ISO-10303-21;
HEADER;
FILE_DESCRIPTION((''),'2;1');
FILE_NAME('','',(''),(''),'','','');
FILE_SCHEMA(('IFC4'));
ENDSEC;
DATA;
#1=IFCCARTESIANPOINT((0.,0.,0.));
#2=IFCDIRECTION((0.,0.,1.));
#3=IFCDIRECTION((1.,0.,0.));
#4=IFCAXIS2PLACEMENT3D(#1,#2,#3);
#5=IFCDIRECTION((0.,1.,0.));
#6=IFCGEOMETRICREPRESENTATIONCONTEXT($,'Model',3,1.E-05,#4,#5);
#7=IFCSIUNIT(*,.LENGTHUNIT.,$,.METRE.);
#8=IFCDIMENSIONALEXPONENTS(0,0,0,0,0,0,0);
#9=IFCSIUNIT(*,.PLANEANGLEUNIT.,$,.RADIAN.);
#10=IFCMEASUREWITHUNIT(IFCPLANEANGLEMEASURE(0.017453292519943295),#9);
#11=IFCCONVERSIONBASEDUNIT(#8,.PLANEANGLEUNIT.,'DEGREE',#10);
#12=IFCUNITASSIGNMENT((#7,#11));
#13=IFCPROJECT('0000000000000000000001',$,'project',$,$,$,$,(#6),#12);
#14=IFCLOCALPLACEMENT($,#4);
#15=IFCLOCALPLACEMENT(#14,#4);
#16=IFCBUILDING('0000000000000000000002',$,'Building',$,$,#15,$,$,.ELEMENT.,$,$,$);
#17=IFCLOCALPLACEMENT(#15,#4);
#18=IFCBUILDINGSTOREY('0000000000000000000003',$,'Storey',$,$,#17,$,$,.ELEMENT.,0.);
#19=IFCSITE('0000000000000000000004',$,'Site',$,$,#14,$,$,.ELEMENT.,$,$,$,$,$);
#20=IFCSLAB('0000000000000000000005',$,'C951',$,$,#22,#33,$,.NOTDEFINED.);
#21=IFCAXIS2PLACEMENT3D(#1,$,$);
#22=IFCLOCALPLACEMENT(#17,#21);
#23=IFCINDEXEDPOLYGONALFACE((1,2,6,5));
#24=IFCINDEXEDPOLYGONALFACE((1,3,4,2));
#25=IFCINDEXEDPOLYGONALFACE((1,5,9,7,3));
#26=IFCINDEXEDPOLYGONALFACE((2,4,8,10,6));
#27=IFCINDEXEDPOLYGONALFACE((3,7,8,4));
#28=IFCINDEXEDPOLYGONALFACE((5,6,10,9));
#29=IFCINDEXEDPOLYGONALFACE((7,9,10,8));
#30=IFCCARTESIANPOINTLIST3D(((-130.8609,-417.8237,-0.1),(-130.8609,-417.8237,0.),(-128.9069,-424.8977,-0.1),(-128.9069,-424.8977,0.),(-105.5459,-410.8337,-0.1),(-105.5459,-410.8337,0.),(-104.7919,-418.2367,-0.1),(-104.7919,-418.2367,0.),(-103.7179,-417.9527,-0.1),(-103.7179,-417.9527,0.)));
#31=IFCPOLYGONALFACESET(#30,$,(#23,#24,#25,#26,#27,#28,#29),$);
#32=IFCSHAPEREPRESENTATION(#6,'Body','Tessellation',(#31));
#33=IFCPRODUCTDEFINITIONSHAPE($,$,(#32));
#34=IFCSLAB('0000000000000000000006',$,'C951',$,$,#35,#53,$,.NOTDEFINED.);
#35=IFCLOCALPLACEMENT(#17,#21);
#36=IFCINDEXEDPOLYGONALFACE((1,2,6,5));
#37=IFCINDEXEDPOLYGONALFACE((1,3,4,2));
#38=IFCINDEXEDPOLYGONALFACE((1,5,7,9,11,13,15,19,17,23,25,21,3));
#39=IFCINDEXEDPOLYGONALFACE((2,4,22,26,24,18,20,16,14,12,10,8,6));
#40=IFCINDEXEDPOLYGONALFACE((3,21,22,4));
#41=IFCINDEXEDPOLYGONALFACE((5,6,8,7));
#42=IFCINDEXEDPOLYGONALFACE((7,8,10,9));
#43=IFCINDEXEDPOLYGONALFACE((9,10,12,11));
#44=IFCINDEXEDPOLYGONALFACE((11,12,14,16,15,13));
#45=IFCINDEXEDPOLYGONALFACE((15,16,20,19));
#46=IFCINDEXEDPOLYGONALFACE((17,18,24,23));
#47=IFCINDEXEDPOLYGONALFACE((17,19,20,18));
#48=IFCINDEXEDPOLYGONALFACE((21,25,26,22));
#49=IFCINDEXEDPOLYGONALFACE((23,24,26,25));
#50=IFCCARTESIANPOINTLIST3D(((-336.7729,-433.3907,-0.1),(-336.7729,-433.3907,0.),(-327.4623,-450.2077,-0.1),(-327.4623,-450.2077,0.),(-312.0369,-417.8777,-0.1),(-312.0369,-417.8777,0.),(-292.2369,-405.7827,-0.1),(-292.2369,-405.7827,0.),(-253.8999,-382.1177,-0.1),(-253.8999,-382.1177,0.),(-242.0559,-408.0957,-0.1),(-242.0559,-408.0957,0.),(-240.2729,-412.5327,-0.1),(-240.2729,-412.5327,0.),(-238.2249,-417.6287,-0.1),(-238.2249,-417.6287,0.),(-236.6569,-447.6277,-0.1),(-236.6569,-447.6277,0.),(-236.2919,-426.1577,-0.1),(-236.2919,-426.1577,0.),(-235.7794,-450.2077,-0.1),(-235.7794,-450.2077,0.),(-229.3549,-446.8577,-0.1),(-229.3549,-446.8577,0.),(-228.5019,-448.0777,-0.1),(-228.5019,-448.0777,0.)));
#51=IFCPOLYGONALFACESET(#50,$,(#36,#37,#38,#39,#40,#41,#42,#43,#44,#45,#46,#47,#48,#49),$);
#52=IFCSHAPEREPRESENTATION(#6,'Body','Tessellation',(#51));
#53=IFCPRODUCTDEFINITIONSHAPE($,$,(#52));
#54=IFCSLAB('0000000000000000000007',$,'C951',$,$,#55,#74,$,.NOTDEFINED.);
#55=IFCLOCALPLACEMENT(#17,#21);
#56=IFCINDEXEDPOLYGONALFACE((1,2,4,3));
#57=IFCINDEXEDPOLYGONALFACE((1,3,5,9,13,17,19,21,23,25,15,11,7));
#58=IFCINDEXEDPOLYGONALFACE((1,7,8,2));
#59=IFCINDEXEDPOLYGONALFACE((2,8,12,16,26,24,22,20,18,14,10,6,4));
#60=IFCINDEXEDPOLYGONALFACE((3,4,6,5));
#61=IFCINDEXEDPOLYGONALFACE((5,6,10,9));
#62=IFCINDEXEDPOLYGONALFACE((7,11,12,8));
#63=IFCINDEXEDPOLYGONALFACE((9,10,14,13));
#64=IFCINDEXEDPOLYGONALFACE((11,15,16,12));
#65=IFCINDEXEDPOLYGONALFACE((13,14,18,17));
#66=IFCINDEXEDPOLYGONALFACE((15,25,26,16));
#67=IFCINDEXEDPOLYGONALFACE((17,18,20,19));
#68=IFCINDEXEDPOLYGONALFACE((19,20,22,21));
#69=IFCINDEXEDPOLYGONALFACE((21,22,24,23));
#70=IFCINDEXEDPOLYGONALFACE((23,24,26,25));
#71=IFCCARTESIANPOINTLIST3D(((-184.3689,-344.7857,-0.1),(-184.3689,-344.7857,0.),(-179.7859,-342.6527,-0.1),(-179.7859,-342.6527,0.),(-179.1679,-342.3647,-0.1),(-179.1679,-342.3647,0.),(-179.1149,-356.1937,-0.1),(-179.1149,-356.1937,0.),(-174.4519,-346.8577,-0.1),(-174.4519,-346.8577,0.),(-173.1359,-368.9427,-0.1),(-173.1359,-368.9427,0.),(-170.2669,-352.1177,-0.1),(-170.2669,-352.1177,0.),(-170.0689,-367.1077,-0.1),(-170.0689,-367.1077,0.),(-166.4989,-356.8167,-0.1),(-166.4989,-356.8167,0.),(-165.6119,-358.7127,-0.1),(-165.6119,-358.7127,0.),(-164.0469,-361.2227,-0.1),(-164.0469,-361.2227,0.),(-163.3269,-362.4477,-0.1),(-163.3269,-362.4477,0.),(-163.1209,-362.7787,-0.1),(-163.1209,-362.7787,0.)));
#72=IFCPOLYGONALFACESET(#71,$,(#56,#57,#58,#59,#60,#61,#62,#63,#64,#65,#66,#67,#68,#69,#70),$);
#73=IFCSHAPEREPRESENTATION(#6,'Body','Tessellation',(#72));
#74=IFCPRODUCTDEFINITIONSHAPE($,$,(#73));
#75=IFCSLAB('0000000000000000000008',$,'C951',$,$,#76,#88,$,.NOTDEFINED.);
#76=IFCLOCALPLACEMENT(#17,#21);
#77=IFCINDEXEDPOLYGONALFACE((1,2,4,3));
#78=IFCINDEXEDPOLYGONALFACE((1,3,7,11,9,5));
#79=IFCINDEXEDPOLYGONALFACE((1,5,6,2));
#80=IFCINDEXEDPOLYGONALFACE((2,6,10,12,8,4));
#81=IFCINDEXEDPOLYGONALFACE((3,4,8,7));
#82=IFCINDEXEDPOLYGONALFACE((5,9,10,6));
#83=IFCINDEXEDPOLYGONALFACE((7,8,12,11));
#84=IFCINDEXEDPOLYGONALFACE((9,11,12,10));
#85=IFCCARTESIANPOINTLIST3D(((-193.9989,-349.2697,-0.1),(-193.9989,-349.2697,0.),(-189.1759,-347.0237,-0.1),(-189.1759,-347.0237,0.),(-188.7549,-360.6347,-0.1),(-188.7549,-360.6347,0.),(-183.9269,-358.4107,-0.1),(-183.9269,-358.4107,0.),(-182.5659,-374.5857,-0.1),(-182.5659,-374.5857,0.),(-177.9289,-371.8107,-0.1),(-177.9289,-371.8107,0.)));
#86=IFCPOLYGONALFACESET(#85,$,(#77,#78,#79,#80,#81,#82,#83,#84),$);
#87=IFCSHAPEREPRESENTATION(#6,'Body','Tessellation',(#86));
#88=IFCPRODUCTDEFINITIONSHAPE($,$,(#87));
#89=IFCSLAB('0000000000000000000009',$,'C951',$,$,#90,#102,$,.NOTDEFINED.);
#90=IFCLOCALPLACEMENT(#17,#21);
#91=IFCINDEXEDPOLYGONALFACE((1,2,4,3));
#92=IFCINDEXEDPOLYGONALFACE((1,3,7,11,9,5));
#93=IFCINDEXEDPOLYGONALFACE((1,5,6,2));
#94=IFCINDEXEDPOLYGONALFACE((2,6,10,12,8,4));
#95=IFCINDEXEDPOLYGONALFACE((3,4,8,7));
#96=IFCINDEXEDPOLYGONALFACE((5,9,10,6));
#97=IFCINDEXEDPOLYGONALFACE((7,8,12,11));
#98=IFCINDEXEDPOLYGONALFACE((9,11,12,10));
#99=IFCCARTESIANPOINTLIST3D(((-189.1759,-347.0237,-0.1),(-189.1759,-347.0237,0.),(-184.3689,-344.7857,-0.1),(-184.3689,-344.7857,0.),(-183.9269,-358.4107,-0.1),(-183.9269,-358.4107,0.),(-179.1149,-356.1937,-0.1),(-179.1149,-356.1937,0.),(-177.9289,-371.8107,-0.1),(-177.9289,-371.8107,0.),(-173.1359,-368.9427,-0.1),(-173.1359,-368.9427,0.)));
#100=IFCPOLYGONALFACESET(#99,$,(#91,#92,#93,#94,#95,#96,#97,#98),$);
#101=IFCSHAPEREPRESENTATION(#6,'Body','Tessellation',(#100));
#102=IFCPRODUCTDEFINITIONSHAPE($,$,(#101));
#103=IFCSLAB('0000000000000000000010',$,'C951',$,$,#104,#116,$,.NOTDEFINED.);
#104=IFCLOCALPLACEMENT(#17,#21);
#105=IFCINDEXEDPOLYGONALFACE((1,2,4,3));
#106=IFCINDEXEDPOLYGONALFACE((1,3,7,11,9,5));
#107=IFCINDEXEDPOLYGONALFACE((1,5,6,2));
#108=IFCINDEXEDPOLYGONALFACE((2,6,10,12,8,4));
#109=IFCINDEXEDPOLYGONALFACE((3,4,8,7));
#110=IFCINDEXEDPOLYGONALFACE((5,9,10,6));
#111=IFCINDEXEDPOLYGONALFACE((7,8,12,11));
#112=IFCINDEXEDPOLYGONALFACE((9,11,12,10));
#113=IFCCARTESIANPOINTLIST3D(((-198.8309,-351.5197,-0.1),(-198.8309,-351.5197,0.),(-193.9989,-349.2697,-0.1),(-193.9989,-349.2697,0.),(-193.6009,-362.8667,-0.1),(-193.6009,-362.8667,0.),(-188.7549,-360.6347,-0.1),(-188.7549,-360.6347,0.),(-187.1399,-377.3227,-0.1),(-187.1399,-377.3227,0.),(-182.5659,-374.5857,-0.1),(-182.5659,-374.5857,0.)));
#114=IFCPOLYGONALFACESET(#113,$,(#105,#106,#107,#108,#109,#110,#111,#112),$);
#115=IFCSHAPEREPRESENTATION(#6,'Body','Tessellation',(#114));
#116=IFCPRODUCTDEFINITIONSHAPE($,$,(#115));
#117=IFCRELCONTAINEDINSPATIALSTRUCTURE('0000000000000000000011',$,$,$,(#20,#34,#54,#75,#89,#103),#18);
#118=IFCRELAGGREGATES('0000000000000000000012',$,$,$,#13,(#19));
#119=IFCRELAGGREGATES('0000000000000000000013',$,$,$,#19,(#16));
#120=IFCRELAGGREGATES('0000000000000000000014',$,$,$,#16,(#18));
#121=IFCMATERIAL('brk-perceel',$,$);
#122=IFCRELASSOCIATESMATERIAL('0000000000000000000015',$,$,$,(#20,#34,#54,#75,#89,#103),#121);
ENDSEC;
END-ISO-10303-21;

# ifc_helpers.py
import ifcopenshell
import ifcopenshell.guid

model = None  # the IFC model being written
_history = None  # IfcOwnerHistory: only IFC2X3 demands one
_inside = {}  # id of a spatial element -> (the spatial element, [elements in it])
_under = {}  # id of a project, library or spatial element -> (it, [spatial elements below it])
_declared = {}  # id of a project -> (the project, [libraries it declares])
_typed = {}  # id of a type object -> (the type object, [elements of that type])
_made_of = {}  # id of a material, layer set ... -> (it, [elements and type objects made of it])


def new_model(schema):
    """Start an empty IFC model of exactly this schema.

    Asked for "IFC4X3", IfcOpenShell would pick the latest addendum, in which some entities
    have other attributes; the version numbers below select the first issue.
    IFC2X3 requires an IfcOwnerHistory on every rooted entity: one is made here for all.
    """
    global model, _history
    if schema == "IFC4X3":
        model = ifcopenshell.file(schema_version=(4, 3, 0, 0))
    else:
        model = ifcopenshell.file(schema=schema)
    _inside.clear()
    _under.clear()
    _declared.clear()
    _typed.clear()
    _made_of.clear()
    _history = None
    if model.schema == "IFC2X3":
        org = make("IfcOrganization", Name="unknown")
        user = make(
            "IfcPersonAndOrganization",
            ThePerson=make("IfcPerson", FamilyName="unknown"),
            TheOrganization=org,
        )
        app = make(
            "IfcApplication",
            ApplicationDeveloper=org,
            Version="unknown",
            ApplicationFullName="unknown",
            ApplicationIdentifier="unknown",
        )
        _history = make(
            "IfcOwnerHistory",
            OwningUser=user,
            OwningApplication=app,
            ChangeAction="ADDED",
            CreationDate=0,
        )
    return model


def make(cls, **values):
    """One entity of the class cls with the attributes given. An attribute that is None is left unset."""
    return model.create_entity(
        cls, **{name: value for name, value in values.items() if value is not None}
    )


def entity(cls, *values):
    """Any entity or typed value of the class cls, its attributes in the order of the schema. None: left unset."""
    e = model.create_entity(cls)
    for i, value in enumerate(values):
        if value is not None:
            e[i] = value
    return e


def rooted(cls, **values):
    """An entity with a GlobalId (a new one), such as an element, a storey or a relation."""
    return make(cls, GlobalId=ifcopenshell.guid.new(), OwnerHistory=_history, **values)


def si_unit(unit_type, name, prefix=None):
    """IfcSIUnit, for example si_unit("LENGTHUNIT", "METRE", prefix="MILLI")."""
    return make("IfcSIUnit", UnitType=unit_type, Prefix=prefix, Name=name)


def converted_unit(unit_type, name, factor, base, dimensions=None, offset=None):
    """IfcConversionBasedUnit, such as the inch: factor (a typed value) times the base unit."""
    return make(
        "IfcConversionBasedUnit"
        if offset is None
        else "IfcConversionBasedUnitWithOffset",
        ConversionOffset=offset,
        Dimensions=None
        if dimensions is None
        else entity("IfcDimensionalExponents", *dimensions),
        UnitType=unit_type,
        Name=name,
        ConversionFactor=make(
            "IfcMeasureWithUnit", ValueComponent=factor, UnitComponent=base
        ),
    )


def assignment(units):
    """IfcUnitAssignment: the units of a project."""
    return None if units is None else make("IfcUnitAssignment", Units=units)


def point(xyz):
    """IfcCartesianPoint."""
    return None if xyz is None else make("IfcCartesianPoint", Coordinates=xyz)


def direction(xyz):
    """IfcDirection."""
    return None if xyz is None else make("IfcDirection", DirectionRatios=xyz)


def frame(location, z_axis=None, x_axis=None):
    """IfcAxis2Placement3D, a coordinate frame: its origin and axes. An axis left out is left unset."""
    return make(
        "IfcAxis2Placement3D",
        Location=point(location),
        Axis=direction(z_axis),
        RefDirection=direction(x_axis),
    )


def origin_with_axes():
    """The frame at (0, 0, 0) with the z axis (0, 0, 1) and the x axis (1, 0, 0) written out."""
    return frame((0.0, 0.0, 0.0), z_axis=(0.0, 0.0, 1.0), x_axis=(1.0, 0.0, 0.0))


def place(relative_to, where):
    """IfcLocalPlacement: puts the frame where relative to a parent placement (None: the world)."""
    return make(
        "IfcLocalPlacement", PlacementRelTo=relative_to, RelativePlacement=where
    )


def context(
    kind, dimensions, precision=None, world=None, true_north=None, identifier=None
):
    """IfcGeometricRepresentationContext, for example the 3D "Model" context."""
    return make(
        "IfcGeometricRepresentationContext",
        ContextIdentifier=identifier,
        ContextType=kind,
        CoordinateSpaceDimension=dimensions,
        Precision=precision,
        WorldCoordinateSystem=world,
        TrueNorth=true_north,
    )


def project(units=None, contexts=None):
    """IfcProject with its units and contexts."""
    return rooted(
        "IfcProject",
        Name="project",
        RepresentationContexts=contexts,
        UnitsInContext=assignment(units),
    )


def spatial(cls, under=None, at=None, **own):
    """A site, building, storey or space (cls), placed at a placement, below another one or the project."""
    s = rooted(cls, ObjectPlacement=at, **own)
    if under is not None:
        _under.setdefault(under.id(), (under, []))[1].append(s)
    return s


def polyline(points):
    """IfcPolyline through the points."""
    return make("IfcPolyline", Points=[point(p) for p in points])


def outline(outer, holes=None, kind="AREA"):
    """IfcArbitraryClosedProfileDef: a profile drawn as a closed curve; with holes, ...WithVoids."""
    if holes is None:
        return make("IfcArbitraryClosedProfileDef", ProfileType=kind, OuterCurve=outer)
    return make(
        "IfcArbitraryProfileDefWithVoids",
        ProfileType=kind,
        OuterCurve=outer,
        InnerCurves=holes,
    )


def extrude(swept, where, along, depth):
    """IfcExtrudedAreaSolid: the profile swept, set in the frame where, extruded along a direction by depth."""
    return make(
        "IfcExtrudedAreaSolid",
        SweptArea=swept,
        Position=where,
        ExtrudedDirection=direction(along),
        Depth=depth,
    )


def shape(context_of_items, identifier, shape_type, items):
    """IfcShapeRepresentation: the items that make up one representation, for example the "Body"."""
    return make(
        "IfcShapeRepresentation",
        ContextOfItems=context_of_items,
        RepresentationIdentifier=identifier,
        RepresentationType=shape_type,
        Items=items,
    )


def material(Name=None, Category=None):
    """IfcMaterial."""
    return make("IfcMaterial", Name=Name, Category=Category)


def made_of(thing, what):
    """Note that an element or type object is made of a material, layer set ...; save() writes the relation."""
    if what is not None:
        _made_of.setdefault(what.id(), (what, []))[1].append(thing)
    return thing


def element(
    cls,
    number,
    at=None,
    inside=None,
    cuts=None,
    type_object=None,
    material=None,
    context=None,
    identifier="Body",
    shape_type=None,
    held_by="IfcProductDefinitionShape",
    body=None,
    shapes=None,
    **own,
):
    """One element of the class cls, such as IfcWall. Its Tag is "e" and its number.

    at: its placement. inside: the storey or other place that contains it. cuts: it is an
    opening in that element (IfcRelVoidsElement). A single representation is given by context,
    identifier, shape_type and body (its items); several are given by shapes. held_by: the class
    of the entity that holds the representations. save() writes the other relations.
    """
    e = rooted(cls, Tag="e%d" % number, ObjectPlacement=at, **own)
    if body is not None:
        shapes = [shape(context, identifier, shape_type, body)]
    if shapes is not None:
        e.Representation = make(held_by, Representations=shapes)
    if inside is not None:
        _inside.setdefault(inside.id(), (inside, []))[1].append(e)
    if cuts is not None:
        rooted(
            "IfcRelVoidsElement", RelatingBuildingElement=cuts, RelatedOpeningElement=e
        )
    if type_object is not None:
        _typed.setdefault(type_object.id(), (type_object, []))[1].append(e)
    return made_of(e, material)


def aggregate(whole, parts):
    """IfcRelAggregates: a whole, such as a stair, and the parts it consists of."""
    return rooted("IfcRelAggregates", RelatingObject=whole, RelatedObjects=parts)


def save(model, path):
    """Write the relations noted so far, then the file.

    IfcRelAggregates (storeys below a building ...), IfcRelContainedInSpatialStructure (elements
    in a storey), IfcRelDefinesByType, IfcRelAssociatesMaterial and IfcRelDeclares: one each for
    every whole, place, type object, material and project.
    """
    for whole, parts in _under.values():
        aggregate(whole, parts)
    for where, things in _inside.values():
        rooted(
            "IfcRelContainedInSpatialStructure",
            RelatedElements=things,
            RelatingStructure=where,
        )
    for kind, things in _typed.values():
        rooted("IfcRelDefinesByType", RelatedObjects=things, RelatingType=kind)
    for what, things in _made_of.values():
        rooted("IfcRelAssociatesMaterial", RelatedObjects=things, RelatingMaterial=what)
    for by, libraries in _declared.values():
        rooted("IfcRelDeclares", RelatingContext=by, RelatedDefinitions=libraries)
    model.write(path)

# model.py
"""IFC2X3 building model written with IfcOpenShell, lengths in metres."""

from ifc_helpers import new_model, entity, si_unit, converted_unit, direction, frame, origin_with_axes, place, context, project, spatial, polyline, outline, extrude, material, element, save


model = new_model("IFC2X3")

# Units and contexts
model_context = context("Model", 3, precision=1e-05, world=origin_with_axes(), true_north=direction((0.0, 1.0, 0.0)))
ifc_project = project(units=[si_unit("LENGTHUNIT", "METRE"), converted_unit("PLANEANGLEUNIT", "DEGREE", entity("IfcPlaneAngleMeasure", 0.017453292519943295), si_unit("PLANEANGLEUNIT", "RADIAN"), dimensions=[0, 0, 0, 0, 0, 0, 0])], contexts=[model_context])

# Site, building, storey
site_placement = place(None, origin_with_axes())
site = spatial("IfcSite", under=ifc_project, at=site_placement, Name="Site", CompositionType="ELEMENT")
building_placement = place(site_placement, origin_with_axes())
building = spatial("IfcBuilding", under=site, at=building_placement, Name="Building", CompositionType="ELEMENT")
storey_placement = place(building_placement, origin_with_axes())
storey = spatial("IfcBuildingStorey", under=building, at=storey_placement, Name="Storey", CompositionType="ELEMENT", Elevation=0.0)

# Slabs
ifc_material = material(Name="brk-perceel")
slab_1_placement = place(storey_placement, frame((0.0, 0.0, -0.1), z_axis=(0.0, 0.0, 1.0), x_axis=(1.0, 0.0, 0.0)))
element("IfcSlab", 1, at=slab_1_placement, inside=storey, material=ifc_material, Name="C951", PredefinedType="NOTDEFINED", context=model_context, shape_type="SweptSolid", body=[
    extrude(outline(polyline([(-104.7919, -418.2367), (-128.9069, -424.8977), (-130.8609, -417.8237), (-105.5459, -410.8337), (-103.7179, -417.9527), (-104.7919, -418.2367)])), origin_with_axes(), (0.0, 0.0, 1.0), 0.1),
])
slab_2_placement = place(storey_placement, frame((0.0, 0.0, -0.1), z_axis=(0.0, 0.0, 1.0), x_axis=(1.0, 0.0, 0.0)))
element("IfcSlab", 2, at=slab_2_placement, inside=storey, material=ifc_material, Name="C951", PredefinedType="NOTDEFINED", context=model_context, shape_type="SweptSolid", body=[
    extrude(outline(polyline([(-336.7729, -433.3907), (-312.0369, -417.8777), (-292.2369, -405.7827), (-253.8999, -382.1177), (-242.0559, -408.0957), (-240.2729, -412.5327), (-238.2249, -417.6287), (-236.2919, -426.1577), (-236.6569, -447.6277), (-229.3549, -446.8577), (-228.5019, -448.0777), (-235.7794, -450.2077), (-327.4623, -450.2077), (-336.7729, -433.3907)])), origin_with_axes(), (0.0, 0.0, 1.0), 0.1),
])
slab_3_placement = place(storey_placement, frame((0.0, 0.0, -0.1), z_axis=(0.0, 0.0, 1.0), x_axis=(1.0, 0.0, 0.0)))
element("IfcSlab", 3, at=slab_3_placement, inside=storey, material=ifc_material, Name="C951", PredefinedType="NOTDEFINED", context=model_context, shape_type="SweptSolid", body=[
    extrude(outline(polyline([(-170.0689, -367.1077), (-173.1359, -368.9427), (-179.1149, -356.1937), (-184.3689, -344.7857), (-179.7859, -342.6527), (-179.1679, -342.3647), (-174.4519, -346.8577), (-170.2669, -352.1177), (-166.4989, -356.8167), (-165.6119, -358.7127), (-164.0469, -361.2227), (-163.3269, -362.4477), (-163.1209, -362.7787), (-170.0689, -367.1077)])), origin_with_axes(), (0.0, 0.0, 1.0), 0.1),
])
slab_4_placement = place(storey_placement, frame((0.0, 0.0, -0.1), z_axis=(0.0, 0.0, 1.0), x_axis=(1.0, 0.0, 0.0)))
element("IfcSlab", 4, at=slab_4_placement, inside=storey, material=ifc_material, Name="C951", PredefinedType="NOTDEFINED", context=model_context, shape_type="SweptSolid", body=[
    extrude(outline(polyline([(-188.7549, -360.6347), (-193.9989, -349.2697), (-189.1759, -347.0237), (-183.9269, -358.4107), (-177.9289, -371.8107), (-182.5659, -374.5857), (-188.7549, -360.6347)])), origin_with_axes(), (0.0, 0.0, 1.0), 0.1),
])
slab_5_placement = place(storey_placement, frame((0.0, 0.0, -0.1), z_axis=(0.0, 0.0, 1.0), x_axis=(1.0, 0.0, 0.0)))
element("IfcSlab", 5, at=slab_5_placement, inside=storey, material=ifc_material, Name="C951", PredefinedType="NOTDEFINED", context=model_context, shape_type="SweptSolid", body=[
    extrude(outline(polyline([(-177.9289, -371.8107), (-183.9269, -358.4107), (-189.1759, -347.0237), (-184.3689, -344.7857), (-179.1149, -356.1937), (-173.1359, -368.9427), (-177.9289, -371.8107)])), origin_with_axes(), (0.0, 0.0, 1.0), 0.1),
])
slab_6_placement = place(storey_placement, frame((0.0, 0.0, -0.1), z_axis=(0.0, 0.0, 1.0), x_axis=(1.0, 0.0, 0.0)))
element("IfcSlab", 6, at=slab_6_placement, inside=storey, material=ifc_material, Name="C951", PredefinedType="NOTDEFINED", context=model_context, shape_type="SweptSolid", body=[
    extrude(outline(polyline([(-193.6009, -362.8667), (-198.8309, -351.5197), (-193.9989, -349.2697), (-188.7549, -360.6347), (-182.5659, -374.5857), (-187.1399, -377.3227), (-193.6009, -362.8667)])), origin_with_axes(), (0.0, 0.0, 1.0), 0.1),
])

save(model, "model.ifc")
